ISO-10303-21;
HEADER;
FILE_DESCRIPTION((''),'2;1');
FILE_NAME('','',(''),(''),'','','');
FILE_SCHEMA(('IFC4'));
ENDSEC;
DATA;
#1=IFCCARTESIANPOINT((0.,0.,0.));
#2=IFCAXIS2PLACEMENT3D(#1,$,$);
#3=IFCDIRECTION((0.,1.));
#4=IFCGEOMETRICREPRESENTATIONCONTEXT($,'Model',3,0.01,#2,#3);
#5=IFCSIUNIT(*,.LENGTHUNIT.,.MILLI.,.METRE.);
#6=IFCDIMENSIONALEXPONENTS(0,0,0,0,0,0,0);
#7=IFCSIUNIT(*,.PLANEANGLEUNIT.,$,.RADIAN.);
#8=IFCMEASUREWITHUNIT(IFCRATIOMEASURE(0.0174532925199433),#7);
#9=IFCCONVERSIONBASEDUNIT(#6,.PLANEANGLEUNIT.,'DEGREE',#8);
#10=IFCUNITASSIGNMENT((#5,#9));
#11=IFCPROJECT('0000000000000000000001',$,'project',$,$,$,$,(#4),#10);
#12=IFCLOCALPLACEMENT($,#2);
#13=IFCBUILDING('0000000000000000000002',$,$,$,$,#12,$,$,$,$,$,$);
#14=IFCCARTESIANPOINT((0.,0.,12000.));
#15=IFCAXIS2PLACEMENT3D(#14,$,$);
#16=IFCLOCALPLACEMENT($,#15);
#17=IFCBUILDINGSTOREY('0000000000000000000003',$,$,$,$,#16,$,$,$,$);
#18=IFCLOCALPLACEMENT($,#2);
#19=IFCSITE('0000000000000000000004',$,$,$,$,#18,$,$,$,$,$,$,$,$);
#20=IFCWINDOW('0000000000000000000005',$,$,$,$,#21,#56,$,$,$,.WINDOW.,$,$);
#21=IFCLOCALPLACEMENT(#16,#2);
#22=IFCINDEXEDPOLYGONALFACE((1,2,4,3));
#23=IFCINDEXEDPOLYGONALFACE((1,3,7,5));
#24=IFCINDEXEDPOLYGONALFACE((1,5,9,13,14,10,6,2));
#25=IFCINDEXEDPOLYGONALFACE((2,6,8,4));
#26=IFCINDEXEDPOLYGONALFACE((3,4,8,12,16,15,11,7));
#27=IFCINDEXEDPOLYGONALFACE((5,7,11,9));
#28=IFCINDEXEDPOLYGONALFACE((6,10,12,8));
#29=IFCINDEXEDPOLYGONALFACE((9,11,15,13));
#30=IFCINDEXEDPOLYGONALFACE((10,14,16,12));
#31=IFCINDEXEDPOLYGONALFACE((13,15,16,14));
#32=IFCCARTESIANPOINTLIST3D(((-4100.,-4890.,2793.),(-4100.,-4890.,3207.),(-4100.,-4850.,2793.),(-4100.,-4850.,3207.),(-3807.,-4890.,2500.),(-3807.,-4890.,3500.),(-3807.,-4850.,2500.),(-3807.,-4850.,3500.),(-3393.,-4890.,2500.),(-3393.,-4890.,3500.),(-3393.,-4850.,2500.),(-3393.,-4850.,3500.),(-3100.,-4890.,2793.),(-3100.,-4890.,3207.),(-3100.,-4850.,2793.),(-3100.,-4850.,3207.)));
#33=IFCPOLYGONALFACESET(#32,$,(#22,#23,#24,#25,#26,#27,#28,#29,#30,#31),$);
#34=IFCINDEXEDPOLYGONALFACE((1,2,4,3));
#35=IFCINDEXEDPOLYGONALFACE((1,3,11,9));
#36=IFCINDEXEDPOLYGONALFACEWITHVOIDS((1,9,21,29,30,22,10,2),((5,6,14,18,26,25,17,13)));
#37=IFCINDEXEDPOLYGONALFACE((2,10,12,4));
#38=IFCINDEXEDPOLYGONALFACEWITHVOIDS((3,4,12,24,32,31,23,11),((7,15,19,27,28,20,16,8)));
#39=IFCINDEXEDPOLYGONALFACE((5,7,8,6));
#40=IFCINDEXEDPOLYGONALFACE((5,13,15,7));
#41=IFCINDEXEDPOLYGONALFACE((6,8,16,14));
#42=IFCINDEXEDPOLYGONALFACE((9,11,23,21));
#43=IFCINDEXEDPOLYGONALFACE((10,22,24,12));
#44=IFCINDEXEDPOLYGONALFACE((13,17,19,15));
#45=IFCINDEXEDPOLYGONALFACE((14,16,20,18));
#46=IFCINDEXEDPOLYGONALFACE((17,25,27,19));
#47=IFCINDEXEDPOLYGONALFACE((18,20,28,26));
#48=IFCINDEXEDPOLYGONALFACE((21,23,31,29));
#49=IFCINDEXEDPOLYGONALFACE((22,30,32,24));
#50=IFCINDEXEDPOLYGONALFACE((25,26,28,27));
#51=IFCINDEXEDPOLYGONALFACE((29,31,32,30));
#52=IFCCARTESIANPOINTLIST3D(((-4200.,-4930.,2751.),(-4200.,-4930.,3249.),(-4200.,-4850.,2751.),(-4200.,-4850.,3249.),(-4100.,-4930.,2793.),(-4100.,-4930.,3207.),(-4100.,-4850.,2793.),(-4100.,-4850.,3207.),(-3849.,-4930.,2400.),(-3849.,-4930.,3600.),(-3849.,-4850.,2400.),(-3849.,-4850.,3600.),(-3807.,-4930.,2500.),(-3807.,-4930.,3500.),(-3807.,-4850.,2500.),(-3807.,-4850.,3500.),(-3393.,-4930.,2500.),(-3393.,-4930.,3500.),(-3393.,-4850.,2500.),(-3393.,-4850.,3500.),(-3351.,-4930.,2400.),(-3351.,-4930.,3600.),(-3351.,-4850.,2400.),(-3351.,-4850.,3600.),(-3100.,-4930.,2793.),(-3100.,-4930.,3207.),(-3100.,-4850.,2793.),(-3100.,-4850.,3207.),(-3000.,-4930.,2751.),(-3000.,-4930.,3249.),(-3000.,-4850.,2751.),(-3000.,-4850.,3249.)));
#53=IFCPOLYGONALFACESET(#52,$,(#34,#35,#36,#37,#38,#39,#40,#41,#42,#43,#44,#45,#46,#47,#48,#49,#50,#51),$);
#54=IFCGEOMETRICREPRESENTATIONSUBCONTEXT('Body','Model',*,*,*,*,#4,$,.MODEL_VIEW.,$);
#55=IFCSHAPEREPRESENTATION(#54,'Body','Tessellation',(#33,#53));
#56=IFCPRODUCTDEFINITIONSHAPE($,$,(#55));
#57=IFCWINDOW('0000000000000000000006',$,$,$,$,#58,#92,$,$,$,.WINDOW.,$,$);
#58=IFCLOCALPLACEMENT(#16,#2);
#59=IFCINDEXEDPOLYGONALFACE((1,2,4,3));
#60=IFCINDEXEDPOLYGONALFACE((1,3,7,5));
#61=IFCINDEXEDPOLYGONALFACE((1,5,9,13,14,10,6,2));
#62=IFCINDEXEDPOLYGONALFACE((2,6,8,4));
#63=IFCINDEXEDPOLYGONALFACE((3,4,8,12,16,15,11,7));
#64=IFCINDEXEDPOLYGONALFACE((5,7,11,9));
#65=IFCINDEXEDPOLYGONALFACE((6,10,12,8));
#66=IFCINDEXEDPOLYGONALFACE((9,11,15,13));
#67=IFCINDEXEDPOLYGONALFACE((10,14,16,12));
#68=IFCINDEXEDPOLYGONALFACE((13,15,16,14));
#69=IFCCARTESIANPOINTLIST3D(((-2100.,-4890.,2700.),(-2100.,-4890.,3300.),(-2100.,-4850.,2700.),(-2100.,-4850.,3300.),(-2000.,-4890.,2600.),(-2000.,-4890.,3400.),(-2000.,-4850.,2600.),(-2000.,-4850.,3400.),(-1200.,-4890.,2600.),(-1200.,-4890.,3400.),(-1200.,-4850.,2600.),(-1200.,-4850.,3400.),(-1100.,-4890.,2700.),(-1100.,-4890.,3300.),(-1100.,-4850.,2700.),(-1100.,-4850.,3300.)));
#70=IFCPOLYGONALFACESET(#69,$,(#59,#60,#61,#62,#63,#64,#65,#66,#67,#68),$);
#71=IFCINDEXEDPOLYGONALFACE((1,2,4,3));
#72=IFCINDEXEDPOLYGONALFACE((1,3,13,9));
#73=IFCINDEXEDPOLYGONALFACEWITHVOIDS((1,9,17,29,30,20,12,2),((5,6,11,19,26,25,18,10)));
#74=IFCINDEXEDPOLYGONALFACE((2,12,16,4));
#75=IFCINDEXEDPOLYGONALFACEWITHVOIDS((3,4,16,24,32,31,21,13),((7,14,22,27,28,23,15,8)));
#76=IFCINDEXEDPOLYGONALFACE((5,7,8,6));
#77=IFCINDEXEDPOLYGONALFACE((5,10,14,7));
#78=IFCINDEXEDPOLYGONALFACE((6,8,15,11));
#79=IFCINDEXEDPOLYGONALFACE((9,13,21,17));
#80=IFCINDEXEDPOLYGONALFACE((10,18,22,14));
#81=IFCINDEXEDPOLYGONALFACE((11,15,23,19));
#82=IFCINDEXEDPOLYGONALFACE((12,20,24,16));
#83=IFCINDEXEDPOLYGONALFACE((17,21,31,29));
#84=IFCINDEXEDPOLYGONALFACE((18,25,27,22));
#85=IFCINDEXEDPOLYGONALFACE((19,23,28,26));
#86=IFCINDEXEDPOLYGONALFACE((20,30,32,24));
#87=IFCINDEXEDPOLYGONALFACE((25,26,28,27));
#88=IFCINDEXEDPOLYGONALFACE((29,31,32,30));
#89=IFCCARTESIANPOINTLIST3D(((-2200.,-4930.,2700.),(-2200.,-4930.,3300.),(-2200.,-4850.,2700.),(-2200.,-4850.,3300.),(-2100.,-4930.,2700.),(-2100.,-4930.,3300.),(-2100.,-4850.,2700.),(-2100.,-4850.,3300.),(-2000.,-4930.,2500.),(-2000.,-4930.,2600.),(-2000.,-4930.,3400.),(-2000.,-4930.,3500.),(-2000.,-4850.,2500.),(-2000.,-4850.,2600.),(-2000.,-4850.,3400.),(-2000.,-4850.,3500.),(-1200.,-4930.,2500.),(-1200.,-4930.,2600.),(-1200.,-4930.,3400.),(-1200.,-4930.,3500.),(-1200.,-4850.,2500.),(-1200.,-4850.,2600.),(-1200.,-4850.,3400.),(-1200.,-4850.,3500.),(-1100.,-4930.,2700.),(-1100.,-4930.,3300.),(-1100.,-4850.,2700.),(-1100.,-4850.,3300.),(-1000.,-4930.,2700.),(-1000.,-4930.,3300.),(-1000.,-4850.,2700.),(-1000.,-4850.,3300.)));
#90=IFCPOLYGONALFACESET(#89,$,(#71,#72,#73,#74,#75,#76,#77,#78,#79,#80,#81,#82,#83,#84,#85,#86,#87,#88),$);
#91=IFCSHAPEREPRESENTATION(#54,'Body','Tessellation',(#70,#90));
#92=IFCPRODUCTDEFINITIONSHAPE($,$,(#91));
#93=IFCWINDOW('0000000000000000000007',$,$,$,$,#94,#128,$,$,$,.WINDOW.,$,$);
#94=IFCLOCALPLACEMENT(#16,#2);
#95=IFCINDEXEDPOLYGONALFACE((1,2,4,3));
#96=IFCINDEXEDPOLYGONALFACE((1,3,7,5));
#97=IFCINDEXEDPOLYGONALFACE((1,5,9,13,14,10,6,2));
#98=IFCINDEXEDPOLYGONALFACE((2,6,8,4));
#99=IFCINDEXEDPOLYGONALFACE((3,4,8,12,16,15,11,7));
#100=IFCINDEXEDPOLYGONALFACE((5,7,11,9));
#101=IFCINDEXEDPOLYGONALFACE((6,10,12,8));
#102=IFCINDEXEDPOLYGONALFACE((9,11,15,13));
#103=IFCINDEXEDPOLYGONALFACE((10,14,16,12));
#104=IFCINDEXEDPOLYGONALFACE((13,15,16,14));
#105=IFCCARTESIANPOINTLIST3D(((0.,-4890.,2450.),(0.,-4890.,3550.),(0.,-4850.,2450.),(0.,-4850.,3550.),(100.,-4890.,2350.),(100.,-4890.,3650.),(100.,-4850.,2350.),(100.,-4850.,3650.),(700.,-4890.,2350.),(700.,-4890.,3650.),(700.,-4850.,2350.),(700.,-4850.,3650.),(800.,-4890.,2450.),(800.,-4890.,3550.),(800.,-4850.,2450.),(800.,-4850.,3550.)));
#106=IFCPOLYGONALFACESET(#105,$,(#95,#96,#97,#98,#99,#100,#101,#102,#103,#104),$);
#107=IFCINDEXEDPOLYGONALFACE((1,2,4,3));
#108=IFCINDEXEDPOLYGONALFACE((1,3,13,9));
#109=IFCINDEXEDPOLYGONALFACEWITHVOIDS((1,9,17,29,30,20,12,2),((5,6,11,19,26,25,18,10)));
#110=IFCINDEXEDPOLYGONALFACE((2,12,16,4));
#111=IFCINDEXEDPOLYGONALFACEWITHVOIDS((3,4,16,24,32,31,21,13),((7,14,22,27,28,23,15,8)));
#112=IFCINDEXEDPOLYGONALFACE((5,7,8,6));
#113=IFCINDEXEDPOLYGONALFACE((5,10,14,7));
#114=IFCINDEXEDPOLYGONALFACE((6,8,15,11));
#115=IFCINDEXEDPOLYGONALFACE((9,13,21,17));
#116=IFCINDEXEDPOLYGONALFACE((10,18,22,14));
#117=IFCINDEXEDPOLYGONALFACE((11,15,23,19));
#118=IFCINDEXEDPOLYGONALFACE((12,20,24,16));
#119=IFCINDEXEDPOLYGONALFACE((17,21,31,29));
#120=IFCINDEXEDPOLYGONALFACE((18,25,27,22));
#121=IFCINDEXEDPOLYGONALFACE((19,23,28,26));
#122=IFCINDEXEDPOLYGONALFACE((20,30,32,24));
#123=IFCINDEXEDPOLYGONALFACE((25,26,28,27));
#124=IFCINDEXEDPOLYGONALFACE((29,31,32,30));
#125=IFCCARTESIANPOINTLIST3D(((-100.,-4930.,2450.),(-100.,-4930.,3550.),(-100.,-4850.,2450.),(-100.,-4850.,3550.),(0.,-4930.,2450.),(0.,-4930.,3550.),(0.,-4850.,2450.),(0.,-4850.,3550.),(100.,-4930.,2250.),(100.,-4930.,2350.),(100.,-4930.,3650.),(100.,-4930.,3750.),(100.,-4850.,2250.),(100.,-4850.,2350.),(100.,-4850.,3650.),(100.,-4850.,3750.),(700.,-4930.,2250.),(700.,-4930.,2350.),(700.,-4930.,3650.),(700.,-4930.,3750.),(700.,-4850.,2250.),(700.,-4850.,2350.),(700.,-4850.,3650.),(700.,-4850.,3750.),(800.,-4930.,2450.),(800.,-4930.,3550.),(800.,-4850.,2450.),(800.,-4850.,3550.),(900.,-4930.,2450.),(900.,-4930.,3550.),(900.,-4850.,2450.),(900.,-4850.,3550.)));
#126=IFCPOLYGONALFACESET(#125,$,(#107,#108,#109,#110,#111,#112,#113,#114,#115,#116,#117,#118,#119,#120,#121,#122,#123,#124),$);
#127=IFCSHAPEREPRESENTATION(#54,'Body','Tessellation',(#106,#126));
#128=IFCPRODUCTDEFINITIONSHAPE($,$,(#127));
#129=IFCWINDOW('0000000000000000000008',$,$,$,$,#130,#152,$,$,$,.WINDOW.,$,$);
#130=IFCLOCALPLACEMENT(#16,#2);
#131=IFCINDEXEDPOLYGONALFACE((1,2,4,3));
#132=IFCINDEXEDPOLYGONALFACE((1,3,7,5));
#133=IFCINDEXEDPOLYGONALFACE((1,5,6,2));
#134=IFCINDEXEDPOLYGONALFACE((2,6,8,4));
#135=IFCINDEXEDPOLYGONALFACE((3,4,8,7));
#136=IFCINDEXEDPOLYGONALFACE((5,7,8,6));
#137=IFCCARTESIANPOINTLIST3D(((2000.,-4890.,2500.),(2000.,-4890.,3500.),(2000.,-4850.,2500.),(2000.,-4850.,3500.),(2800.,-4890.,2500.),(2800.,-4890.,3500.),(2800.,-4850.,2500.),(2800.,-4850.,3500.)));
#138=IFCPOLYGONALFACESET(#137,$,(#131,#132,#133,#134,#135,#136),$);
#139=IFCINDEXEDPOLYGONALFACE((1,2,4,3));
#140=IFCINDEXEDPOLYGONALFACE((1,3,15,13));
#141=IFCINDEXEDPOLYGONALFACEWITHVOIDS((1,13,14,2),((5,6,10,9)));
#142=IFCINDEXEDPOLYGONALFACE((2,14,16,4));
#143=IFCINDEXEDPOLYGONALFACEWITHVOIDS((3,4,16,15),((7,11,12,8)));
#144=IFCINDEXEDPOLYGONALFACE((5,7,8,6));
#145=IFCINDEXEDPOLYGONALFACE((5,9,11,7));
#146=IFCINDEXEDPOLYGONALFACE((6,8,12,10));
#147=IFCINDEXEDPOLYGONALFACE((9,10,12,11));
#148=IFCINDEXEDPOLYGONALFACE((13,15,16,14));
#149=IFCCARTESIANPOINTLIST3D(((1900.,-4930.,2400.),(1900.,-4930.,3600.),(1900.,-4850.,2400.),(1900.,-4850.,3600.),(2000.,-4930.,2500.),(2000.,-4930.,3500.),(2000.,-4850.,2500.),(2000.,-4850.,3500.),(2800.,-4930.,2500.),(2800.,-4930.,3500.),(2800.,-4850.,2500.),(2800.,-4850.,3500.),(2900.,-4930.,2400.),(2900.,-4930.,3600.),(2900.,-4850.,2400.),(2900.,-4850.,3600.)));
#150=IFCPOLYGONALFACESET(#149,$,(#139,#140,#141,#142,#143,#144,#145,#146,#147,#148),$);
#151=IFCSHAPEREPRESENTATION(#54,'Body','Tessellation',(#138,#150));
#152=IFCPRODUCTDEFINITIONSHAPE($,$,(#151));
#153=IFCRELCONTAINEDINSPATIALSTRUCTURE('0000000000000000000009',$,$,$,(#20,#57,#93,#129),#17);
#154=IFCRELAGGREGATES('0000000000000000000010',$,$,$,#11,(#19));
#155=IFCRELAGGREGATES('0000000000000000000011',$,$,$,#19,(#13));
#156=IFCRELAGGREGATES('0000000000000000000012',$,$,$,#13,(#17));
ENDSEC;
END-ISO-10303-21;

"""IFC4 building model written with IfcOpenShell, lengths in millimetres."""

from ifc_helpers import new_model, entity, si_unit, converted_unit, direction, frame, origin, place, context, subcontext, project, spatial, element, save


model = new_model("IFC4")

# Units and contexts
model_context = context("Model", 3, precision=0.01, world=origin(), true_north=direction((0.0, 1.0)))
body_context = subcontext(model_context, "Body", "Model", "MODEL_VIEW")
ifc_project = project(units=[si_unit("LENGTHUNIT", "METRE", prefix="MILLI"), converted_unit("PLANEANGLEUNIT", "DEGREE", entity("IfcRatioMeasure", 0.0174532925199433), si_unit("PLANEANGLEUNIT", "RADIAN"), dimensions=[0, 0, 0, 0, 0, 0, 0])], contexts=[model_context])

# Site, building, storey
site_placement = place(None, origin())
site = spatial("IfcSite", under=ifc_project, at=site_placement)
building_placement = place(None, origin())
building = spatial("IfcBuilding", under=site, at=building_placement)
storey_placement = place(None, frame((0.0, 0.0, 12000.0)))
storey = spatial("IfcBuildingStorey", under=building, at=storey_placement)

# Shared definitions
cartesian_point_1 = entity("IfcCartesianPoint", [-500.0, -207.0])
shared_polyline_1 = entity("IfcPolyline", [cartesian_point_1, entity("IfcCartesianPoint", [-500.0, 207.0]), entity("IfcCartesianPoint", [-207.0, 500.0]), entity("IfcCartesianPoint", [207.0, 500.0]), entity("IfcCartesianPoint", [500.0, 207.0]), entity("IfcCartesianPoint", [500.0, -207.0]), entity("IfcCartesianPoint", [207.0, -500.0]), entity("IfcCartesianPoint", [-207.0, -500.0]), cartesian_point_1])
cartesian_point_2 = entity("IfcCartesianPoint", [-500.0, -300.0])
shared_polyline_2 = entity("IfcPolyline", [cartesian_point_2, entity("IfcCartesianPoint", [-500.0, 300.0]), entity("IfcCartesianPoint", [-400.0, 400.0]), entity("IfcCartesianPoint", [400.0, 400.0]), entity("IfcCartesianPoint", [500.0, 300.0]), entity("IfcCartesianPoint", [500.0, -300.0]), entity("IfcCartesianPoint", [400.0, -400.0]), entity("IfcCartesianPoint", [-400.0, -400.0]), cartesian_point_2])
cartesian_point_3 = entity("IfcCartesianPoint", [-400.0, -550.0])
shared_polyline_3 = entity("IfcPolyline", [cartesian_point_3, entity("IfcCartesianPoint", [-400.0, 550.0]), entity("IfcCartesianPoint", [-300.0, 650.0]), entity("IfcCartesianPoint", [300.0, 650.0]), entity("IfcCartesianPoint", [400.0, 550.0]), entity("IfcCartesianPoint", [400.0, -550.0]), entity("IfcCartesianPoint", [300.0, -650.0]), entity("IfcCartesianPoint", [-300.0, -650.0]), cartesian_point_3])
cartesian_point_4 = entity("IfcCartesianPoint", [-400.0, -500.0])
shared_polyline_4 = entity("IfcPolyline", [cartesian_point_4, entity("IfcCartesianPoint", [-400.0, 500.0]), entity("IfcCartesianPoint", [-400.0, 500.0]), entity("IfcCartesianPoint", [400.0, 500.0]), entity("IfcCartesianPoint", [400.0, 500.0]), entity("IfcCartesianPoint", [400.0, -500.0]), entity("IfcCartesianPoint", [400.0, -500.0]), entity("IfcCartesianPoint", [-400.0, -500.0]), cartesian_point_4])

# Shared definitions
wall_1_placement = place(storey_placement, frame((-100.0, -4900.0, 0.0), z_axis=(0.0, 0.0, 1.0), x_axis=(1.0, 0.0, 0.0)))
window_1_placement = place(wall_1_placement, frame((-3500.0, 50.0, 3000.0)))
window_2_placement = place(wall_1_placement, frame((-1500.0, 50.0, 3000.0)))
window_3_placement = place(wall_1_placement, frame((500.0, 50.0, 3000.0)))
window_4_placement = place(wall_1_placement, frame((2500.0, 50.0, 3000.0)))

# Windows
cartesian_point_5 = entity("IfcCartesianPoint", [-600.0, -249.0])
element("IfcWindow", 1, at=window_1_placement, inside=storey, PredefinedType="WINDOW", context=body_context, shape_type="SweptSolid", body=[
    entity("IfcExtrudedAreaSolid", entity("IfcArbitraryClosedProfileDef", "AREA", None, shared_polyline_1), entity("IfcAxis2Placement3D", entity("IfcCartesianPoint", [0.0, 0.0, 0.0]), entity("IfcDirection", [0.0, -1.0, 0.0]), entity("IfcDirection", [1.0, 0.0, 0.0])), entity("IfcDirection", [0.0, 0.0, 1.0]), 40.0),
    entity("IfcExtrudedAreaSolid", entity("IfcArbitraryProfileDefWithVoids", "AREA", None, entity("IfcPolyline", [cartesian_point_5, entity("IfcCartesianPoint", [-600.0, 249.0]), entity("IfcCartesianPoint", [-249.0, 600.0]), entity("IfcCartesianPoint", [249.0, 600.0]), entity("IfcCartesianPoint", [600.0, 249.0]), entity("IfcCartesianPoint", [600.0, -249.0]), entity("IfcCartesianPoint", [249.0, -600.0]), entity("IfcCartesianPoint", [-249.0, -600.0]), cartesian_point_5]), [shared_polyline_1]), entity("IfcAxis2Placement3D", entity("IfcCartesianPoint", [0.0, 0.0, 0.0]), entity("IfcDirection", [0.0, -1.0, 0.0]), entity("IfcDirection", [1.0, 0.0, 0.0])), entity("IfcDirection", [0.0, 0.0, 1.0]), 80.0),
])
cartesian_point_6 = entity("IfcCartesianPoint", [-600.0, -300.0])
element("IfcWindow", 2, at=window_2_placement, inside=storey, PredefinedType="WINDOW", context=body_context, shape_type="SweptSolid", body=[
    entity("IfcExtrudedAreaSolid", entity("IfcArbitraryClosedProfileDef", "AREA", None, shared_polyline_2), entity("IfcAxis2Placement3D", entity("IfcCartesianPoint", [0.0, 0.0, 0.0]), entity("IfcDirection", [0.0, -1.0, 0.0]), entity("IfcDirection", [1.0, 0.0, 0.0])), entity("IfcDirection", [0.0, 0.0, 1.0]), 40.0),
    entity("IfcExtrudedAreaSolid", entity("IfcArbitraryProfileDefWithVoids", "AREA", None, entity("IfcPolyline", [cartesian_point_6, entity("IfcCartesianPoint", [-600.0, 300.0]), entity("IfcCartesianPoint", [-400.0, 500.0]), entity("IfcCartesianPoint", [400.0, 500.0]), entity("IfcCartesianPoint", [600.0, 300.0]), entity("IfcCartesianPoint", [600.0, -300.0]), entity("IfcCartesianPoint", [400.0, -500.0]), entity("IfcCartesianPoint", [-400.0, -500.0]), cartesian_point_6]), [shared_polyline_2]), entity("IfcAxis2Placement3D", entity("IfcCartesianPoint", [0.0, 0.0, 0.0]), entity("IfcDirection", [0.0, -1.0, 0.0]), entity("IfcDirection", [1.0, 0.0, 0.0])), entity("IfcDirection", [0.0, 0.0, 1.0]), 80.0),
])
cartesian_point_7 = entity("IfcCartesianPoint", [-500.0, -550.0])
element("IfcWindow", 3, at=window_3_placement, inside=storey, PredefinedType="WINDOW", context=body_context, shape_type="SweptSolid", body=[
    entity("IfcExtrudedAreaSolid", entity("IfcArbitraryClosedProfileDef", "AREA", None, shared_polyline_3), entity("IfcAxis2Placement3D", entity("IfcCartesianPoint", [0.0, 0.0, 0.0]), entity("IfcDirection", [0.0, -1.0, 0.0]), entity("IfcDirection", [1.0, 0.0, 0.0])), entity("IfcDirection", [0.0, 0.0, 1.0]), 40.0),
    entity("IfcExtrudedAreaSolid", entity("IfcArbitraryProfileDefWithVoids", "AREA", None, entity("IfcPolyline", [cartesian_point_7, entity("IfcCartesianPoint", [-500.0, 550.0]), entity("IfcCartesianPoint", [-300.0, 750.0]), entity("IfcCartesianPoint", [300.0, 750.0]), entity("IfcCartesianPoint", [500.0, 550.0]), entity("IfcCartesianPoint", [500.0, -550.0]), entity("IfcCartesianPoint", [300.0, -750.0]), entity("IfcCartesianPoint", [-300.0, -750.0]), cartesian_point_7]), [shared_polyline_3]), entity("IfcAxis2Placement3D", entity("IfcCartesianPoint", [0.0, 0.0, 0.0]), entity("IfcDirection", [0.0, -1.0, 0.0]), entity("IfcDirection", [1.0, 0.0, 0.0])), entity("IfcDirection", [0.0, 0.0, 1.0]), 80.0),
])
cartesian_point_8 = entity("IfcCartesianPoint", [-500.0, -600.0])
element("IfcWindow", 4, at=window_4_placement, inside=storey, PredefinedType="WINDOW", context=body_context, shape_type="SweptSolid", body=[
    entity("IfcExtrudedAreaSolid", entity("IfcArbitraryClosedProfileDef", "AREA", None, shared_polyline_4), entity("IfcAxis2Placement3D", entity("IfcCartesianPoint", [0.0, 0.0, 0.0]), entity("IfcDirection", [0.0, -1.0, 0.0]), entity("IfcDirection", [1.0, 0.0, 0.0])), entity("IfcDirection", [0.0, 0.0, 1.0]), 40.0),
    entity("IfcExtrudedAreaSolid", entity("IfcArbitraryProfileDefWithVoids", "AREA", None, entity("IfcPolyline", [cartesian_point_8, entity("IfcCartesianPoint", [-500.0, 600.0]), entity("IfcCartesianPoint", [-500.0, 600.0]), entity("IfcCartesianPoint", [500.0, 600.0]), entity("IfcCartesianPoint", [500.0, 600.0]), entity("IfcCartesianPoint", [500.0, -600.0]), entity("IfcCartesianPoint", [500.0, -600.0]), entity("IfcCartesianPoint", [-500.0, -600.0]), cartesian_point_8]), [shared_polyline_4]), entity("IfcAxis2Placement3D", entity("IfcCartesianPoint", [0.0, 0.0, 0.0]), entity("IfcDirection", [0.0, -1.0, 0.0]), entity("IfcDirection", [1.0, 0.0, 0.0])), entity("IfcDirection", [0.0, 0.0, 1.0]), 80.0),
])

save(model, "model.ifc")
